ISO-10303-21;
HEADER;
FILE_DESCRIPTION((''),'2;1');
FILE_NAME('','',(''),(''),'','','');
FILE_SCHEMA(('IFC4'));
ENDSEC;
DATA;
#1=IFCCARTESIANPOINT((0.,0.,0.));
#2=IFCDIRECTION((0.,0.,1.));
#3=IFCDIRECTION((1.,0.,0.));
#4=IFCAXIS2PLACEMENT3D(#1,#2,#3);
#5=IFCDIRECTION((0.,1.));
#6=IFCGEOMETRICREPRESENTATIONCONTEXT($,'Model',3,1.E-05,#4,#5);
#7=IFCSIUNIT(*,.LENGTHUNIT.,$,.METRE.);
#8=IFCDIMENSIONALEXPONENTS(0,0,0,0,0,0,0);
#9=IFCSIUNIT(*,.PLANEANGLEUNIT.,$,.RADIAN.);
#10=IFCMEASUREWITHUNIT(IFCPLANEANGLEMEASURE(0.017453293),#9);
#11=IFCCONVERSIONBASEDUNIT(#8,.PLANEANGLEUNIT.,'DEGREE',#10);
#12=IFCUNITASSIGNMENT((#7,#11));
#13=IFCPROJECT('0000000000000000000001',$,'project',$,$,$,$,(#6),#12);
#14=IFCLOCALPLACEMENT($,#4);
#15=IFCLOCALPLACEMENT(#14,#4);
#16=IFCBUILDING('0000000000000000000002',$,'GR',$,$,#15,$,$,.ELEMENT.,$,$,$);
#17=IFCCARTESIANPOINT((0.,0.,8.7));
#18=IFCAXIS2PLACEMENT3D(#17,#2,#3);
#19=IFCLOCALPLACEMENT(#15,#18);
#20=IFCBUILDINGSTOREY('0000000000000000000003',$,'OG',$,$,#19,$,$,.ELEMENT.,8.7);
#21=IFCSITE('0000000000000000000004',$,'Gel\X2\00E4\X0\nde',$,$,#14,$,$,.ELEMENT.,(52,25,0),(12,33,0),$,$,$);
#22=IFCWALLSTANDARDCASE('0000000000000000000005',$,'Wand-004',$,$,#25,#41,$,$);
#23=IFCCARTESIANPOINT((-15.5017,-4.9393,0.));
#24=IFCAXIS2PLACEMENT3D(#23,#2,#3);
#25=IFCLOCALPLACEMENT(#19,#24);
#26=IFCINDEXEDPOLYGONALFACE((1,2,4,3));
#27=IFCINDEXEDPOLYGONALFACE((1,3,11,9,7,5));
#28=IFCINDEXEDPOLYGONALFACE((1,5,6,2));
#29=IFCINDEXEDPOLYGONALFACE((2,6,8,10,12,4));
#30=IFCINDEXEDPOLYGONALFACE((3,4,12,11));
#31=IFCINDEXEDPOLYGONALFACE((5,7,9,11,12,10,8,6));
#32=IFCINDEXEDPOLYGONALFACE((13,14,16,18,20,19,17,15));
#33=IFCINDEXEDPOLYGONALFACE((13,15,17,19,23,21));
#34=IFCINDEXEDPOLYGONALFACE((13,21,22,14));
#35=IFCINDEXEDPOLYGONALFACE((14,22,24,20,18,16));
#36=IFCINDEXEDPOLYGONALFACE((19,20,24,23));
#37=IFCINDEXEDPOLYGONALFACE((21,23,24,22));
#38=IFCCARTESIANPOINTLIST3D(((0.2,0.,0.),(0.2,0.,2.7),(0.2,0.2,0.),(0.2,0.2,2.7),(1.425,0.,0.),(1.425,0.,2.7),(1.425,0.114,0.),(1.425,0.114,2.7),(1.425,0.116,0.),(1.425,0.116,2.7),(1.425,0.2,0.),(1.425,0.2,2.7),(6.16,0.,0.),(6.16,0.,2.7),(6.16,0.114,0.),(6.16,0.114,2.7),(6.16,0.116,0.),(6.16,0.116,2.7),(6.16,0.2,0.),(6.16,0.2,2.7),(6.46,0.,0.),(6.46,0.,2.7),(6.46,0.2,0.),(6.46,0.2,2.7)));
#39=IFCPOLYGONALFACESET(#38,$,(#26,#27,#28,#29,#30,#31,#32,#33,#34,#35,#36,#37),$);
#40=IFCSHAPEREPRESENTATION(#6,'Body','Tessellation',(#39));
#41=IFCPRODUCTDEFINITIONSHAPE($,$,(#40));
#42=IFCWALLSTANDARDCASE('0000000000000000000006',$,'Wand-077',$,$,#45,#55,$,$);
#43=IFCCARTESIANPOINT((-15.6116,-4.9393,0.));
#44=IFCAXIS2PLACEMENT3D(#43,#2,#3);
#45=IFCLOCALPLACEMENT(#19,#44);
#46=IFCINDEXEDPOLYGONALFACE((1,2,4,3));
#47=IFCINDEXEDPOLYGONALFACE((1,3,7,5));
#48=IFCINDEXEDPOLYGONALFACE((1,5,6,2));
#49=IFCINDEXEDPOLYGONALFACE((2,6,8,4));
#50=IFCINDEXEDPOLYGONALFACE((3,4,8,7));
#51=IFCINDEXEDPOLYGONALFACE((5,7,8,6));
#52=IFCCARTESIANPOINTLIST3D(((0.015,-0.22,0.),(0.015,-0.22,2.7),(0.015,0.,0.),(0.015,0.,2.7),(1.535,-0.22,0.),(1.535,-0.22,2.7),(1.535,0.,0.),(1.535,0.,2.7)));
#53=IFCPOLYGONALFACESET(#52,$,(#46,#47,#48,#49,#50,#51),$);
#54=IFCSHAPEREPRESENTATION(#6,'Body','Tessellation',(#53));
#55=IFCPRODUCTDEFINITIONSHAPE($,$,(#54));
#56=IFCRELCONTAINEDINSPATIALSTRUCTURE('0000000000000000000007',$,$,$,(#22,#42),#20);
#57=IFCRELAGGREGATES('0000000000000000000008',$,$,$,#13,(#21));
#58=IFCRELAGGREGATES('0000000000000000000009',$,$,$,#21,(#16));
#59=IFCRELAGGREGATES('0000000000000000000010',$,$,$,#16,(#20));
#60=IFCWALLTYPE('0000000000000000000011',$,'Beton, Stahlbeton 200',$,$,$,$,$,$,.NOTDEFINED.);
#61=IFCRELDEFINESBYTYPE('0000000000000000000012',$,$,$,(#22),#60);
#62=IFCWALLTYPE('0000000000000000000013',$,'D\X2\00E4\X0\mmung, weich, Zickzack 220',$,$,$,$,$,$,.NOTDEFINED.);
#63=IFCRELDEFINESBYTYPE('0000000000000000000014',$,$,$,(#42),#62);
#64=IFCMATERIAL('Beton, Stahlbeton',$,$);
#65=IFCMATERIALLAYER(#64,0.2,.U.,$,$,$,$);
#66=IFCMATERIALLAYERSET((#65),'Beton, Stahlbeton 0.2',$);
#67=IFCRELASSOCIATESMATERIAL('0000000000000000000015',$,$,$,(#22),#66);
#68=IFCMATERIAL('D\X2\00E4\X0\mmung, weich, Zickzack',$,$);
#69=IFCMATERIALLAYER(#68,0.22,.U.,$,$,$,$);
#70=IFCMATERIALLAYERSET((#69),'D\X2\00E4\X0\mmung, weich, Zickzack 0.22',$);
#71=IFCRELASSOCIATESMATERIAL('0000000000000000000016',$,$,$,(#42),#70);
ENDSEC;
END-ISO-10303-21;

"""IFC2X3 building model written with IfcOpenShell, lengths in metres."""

from ifc_helpers import new_model, entity, si_unit, converted_unit, direction, frame, origin_with_axes, origin_2d_with_axis, place, context, project, spatial, polyline, rectangle, outline, extrude, material, layer, layer_set, layer_usage, type_object, element, save


model = new_model("IFC2X3")

# Units and contexts
model_context = context("Model", 3, precision=1e-05, world=origin_with_axes(), true_north=direction((0.0, 1.0)))
ifc_project = project(units=[si_unit("LENGTHUNIT", "METRE"), converted_unit("PLANEANGLEUNIT", "DEGREE", entity("IfcPlaneAngleMeasure", 0.017453293), si_unit("PLANEANGLEUNIT", "RADIAN"), dimensions=[0, 0, 0, 0, 0, 0, 0])], contexts=[model_context])

# Site, building, storey
site_placement = place(None, origin_with_axes())
site = spatial("IfcSite", under=ifc_project, at=site_placement, Name="Gelände", CompositionType="ELEMENT", RefLatitude=(52, 25, 0), RefLongitude=(12, 33, 0))
building_placement = place(site_placement, origin_with_axes())
building = spatial("IfcBuilding", under=site, at=building_placement, Name="GR", CompositionType="ELEMENT")
storey_placement = place(building_placement, frame((0.0, 0.0, 8.7), z_axis=(0.0, 0.0, 1.0), x_axis=(1.0, 0.0, 0.0)))
storey = spatial("IfcBuildingStorey", under=building, at=storey_placement, Name="OG", CompositionType="ELEMENT", Elevation=8.7)

# Shared definitions
ifc_material_1 = material(Name="Dämmung, weich, Zickzack")
ifc_material_2 = material(Name="Beton, Stahlbeton")
ifc_layer_1 = layer(ifc_material_2, 0.2, ventilated="UNKNOWN")
ifc_layer_set_1 = layer_set([ifc_layer_1], Name="Beton, Stahlbeton 0.2")
wall_type_1 = type_object("IfcWallType", Name="Beton, Stahlbeton 200", PredefinedType="NOTDEFINED")

# Wall, opening
ifc_layer_usage_1 = layer_usage(ifc_layer_set_1, "AXIS2", "POSITIVE", 0.0)
wall_1_placement = place(storey_placement, frame((-15.5017, -4.9393, 0.0), z_axis=(0.0, 0.0, 1.0), x_axis=(1.0, 0.0, 0.0)))
wall_1 = element("IfcWallStandardCase", 1, at=wall_1_placement, inside=storey, type_object=wall_type_1, material=ifc_layer_usage_1, Name="Wand-004", context=model_context, shape_type="SweptSolid", body=[
    extrude(outline(polyline([(0.2, 0.0), (6.46, 0.0), (6.46, 0.2), (0.2, 0.2), (0.2, 0.0)])), origin_with_axes(), (0.0, 0.0, 1.0), 2.7),
])
opening_1_placement = place(wall_1_placement, frame((3.7925, 0.0, 0.0), z_axis=(0.0, 0.0, 1.0), x_axis=(1.0, 0.0, 0.0)))
element("IfcOpeningElement", 2, at=opening_1_placement, cuts=wall_1, context=model_context, shape_type="SweptSolid", body=[
    extrude(rectangle(XDim=4.735, YDim=2.7, at=origin_2d_with_axis()), frame((0.0, -0.401, 1.35), z_axis=(0.0, 1.0, 0.0), x_axis=(1.0, 0.0, 0.0)), (0.0, 0.0, 1.0), 0.517),
    extrude(rectangle(XDim=4.735, YDim=2.7, at=origin_2d_with_axis()), frame((0.0, 0.601, 1.35), z_axis=(0.0, -1.0, 0.0), x_axis=(1.0, 0.0, 0.0)), (0.0, 0.0, 1.0), 0.487),
])

# Wall
ifc_layer_2 = layer(ifc_material_1, 0.22, ventilated="UNKNOWN")
ifc_layer_set_2 = layer_set([ifc_layer_2], Name="Dämmung, weich, Zickzack 0.22")
ifc_layer_usage_2 = layer_usage(ifc_layer_set_2, "AXIS2", "NEGATIVE", 0.0)
wall_type_2 = type_object("IfcWallType", Name="Dämmung, weich, Zickzack 220", PredefinedType="NOTDEFINED")
wall_2_placement = place(storey_placement, frame((-15.6116, -4.9393, 0.0), z_axis=(0.0, 0.0, 1.0), x_axis=(1.0, 0.0, 0.0)))
element("IfcWallStandardCase", 3, at=wall_2_placement, inside=storey, type_object=wall_type_2, material=ifc_layer_usage_2, Name="Wand-077", context=model_context, shape_type="SweptSolid", body=[
    extrude(outline(polyline([(0.015, -0.22), (1.535, -0.22), (1.535, 0.0), (0.015, 0.0), (0.015, -0.22)])), origin_with_axes(), (0.0, 0.0, 1.0), 2.7),
])

save(model, "model.ifc")
